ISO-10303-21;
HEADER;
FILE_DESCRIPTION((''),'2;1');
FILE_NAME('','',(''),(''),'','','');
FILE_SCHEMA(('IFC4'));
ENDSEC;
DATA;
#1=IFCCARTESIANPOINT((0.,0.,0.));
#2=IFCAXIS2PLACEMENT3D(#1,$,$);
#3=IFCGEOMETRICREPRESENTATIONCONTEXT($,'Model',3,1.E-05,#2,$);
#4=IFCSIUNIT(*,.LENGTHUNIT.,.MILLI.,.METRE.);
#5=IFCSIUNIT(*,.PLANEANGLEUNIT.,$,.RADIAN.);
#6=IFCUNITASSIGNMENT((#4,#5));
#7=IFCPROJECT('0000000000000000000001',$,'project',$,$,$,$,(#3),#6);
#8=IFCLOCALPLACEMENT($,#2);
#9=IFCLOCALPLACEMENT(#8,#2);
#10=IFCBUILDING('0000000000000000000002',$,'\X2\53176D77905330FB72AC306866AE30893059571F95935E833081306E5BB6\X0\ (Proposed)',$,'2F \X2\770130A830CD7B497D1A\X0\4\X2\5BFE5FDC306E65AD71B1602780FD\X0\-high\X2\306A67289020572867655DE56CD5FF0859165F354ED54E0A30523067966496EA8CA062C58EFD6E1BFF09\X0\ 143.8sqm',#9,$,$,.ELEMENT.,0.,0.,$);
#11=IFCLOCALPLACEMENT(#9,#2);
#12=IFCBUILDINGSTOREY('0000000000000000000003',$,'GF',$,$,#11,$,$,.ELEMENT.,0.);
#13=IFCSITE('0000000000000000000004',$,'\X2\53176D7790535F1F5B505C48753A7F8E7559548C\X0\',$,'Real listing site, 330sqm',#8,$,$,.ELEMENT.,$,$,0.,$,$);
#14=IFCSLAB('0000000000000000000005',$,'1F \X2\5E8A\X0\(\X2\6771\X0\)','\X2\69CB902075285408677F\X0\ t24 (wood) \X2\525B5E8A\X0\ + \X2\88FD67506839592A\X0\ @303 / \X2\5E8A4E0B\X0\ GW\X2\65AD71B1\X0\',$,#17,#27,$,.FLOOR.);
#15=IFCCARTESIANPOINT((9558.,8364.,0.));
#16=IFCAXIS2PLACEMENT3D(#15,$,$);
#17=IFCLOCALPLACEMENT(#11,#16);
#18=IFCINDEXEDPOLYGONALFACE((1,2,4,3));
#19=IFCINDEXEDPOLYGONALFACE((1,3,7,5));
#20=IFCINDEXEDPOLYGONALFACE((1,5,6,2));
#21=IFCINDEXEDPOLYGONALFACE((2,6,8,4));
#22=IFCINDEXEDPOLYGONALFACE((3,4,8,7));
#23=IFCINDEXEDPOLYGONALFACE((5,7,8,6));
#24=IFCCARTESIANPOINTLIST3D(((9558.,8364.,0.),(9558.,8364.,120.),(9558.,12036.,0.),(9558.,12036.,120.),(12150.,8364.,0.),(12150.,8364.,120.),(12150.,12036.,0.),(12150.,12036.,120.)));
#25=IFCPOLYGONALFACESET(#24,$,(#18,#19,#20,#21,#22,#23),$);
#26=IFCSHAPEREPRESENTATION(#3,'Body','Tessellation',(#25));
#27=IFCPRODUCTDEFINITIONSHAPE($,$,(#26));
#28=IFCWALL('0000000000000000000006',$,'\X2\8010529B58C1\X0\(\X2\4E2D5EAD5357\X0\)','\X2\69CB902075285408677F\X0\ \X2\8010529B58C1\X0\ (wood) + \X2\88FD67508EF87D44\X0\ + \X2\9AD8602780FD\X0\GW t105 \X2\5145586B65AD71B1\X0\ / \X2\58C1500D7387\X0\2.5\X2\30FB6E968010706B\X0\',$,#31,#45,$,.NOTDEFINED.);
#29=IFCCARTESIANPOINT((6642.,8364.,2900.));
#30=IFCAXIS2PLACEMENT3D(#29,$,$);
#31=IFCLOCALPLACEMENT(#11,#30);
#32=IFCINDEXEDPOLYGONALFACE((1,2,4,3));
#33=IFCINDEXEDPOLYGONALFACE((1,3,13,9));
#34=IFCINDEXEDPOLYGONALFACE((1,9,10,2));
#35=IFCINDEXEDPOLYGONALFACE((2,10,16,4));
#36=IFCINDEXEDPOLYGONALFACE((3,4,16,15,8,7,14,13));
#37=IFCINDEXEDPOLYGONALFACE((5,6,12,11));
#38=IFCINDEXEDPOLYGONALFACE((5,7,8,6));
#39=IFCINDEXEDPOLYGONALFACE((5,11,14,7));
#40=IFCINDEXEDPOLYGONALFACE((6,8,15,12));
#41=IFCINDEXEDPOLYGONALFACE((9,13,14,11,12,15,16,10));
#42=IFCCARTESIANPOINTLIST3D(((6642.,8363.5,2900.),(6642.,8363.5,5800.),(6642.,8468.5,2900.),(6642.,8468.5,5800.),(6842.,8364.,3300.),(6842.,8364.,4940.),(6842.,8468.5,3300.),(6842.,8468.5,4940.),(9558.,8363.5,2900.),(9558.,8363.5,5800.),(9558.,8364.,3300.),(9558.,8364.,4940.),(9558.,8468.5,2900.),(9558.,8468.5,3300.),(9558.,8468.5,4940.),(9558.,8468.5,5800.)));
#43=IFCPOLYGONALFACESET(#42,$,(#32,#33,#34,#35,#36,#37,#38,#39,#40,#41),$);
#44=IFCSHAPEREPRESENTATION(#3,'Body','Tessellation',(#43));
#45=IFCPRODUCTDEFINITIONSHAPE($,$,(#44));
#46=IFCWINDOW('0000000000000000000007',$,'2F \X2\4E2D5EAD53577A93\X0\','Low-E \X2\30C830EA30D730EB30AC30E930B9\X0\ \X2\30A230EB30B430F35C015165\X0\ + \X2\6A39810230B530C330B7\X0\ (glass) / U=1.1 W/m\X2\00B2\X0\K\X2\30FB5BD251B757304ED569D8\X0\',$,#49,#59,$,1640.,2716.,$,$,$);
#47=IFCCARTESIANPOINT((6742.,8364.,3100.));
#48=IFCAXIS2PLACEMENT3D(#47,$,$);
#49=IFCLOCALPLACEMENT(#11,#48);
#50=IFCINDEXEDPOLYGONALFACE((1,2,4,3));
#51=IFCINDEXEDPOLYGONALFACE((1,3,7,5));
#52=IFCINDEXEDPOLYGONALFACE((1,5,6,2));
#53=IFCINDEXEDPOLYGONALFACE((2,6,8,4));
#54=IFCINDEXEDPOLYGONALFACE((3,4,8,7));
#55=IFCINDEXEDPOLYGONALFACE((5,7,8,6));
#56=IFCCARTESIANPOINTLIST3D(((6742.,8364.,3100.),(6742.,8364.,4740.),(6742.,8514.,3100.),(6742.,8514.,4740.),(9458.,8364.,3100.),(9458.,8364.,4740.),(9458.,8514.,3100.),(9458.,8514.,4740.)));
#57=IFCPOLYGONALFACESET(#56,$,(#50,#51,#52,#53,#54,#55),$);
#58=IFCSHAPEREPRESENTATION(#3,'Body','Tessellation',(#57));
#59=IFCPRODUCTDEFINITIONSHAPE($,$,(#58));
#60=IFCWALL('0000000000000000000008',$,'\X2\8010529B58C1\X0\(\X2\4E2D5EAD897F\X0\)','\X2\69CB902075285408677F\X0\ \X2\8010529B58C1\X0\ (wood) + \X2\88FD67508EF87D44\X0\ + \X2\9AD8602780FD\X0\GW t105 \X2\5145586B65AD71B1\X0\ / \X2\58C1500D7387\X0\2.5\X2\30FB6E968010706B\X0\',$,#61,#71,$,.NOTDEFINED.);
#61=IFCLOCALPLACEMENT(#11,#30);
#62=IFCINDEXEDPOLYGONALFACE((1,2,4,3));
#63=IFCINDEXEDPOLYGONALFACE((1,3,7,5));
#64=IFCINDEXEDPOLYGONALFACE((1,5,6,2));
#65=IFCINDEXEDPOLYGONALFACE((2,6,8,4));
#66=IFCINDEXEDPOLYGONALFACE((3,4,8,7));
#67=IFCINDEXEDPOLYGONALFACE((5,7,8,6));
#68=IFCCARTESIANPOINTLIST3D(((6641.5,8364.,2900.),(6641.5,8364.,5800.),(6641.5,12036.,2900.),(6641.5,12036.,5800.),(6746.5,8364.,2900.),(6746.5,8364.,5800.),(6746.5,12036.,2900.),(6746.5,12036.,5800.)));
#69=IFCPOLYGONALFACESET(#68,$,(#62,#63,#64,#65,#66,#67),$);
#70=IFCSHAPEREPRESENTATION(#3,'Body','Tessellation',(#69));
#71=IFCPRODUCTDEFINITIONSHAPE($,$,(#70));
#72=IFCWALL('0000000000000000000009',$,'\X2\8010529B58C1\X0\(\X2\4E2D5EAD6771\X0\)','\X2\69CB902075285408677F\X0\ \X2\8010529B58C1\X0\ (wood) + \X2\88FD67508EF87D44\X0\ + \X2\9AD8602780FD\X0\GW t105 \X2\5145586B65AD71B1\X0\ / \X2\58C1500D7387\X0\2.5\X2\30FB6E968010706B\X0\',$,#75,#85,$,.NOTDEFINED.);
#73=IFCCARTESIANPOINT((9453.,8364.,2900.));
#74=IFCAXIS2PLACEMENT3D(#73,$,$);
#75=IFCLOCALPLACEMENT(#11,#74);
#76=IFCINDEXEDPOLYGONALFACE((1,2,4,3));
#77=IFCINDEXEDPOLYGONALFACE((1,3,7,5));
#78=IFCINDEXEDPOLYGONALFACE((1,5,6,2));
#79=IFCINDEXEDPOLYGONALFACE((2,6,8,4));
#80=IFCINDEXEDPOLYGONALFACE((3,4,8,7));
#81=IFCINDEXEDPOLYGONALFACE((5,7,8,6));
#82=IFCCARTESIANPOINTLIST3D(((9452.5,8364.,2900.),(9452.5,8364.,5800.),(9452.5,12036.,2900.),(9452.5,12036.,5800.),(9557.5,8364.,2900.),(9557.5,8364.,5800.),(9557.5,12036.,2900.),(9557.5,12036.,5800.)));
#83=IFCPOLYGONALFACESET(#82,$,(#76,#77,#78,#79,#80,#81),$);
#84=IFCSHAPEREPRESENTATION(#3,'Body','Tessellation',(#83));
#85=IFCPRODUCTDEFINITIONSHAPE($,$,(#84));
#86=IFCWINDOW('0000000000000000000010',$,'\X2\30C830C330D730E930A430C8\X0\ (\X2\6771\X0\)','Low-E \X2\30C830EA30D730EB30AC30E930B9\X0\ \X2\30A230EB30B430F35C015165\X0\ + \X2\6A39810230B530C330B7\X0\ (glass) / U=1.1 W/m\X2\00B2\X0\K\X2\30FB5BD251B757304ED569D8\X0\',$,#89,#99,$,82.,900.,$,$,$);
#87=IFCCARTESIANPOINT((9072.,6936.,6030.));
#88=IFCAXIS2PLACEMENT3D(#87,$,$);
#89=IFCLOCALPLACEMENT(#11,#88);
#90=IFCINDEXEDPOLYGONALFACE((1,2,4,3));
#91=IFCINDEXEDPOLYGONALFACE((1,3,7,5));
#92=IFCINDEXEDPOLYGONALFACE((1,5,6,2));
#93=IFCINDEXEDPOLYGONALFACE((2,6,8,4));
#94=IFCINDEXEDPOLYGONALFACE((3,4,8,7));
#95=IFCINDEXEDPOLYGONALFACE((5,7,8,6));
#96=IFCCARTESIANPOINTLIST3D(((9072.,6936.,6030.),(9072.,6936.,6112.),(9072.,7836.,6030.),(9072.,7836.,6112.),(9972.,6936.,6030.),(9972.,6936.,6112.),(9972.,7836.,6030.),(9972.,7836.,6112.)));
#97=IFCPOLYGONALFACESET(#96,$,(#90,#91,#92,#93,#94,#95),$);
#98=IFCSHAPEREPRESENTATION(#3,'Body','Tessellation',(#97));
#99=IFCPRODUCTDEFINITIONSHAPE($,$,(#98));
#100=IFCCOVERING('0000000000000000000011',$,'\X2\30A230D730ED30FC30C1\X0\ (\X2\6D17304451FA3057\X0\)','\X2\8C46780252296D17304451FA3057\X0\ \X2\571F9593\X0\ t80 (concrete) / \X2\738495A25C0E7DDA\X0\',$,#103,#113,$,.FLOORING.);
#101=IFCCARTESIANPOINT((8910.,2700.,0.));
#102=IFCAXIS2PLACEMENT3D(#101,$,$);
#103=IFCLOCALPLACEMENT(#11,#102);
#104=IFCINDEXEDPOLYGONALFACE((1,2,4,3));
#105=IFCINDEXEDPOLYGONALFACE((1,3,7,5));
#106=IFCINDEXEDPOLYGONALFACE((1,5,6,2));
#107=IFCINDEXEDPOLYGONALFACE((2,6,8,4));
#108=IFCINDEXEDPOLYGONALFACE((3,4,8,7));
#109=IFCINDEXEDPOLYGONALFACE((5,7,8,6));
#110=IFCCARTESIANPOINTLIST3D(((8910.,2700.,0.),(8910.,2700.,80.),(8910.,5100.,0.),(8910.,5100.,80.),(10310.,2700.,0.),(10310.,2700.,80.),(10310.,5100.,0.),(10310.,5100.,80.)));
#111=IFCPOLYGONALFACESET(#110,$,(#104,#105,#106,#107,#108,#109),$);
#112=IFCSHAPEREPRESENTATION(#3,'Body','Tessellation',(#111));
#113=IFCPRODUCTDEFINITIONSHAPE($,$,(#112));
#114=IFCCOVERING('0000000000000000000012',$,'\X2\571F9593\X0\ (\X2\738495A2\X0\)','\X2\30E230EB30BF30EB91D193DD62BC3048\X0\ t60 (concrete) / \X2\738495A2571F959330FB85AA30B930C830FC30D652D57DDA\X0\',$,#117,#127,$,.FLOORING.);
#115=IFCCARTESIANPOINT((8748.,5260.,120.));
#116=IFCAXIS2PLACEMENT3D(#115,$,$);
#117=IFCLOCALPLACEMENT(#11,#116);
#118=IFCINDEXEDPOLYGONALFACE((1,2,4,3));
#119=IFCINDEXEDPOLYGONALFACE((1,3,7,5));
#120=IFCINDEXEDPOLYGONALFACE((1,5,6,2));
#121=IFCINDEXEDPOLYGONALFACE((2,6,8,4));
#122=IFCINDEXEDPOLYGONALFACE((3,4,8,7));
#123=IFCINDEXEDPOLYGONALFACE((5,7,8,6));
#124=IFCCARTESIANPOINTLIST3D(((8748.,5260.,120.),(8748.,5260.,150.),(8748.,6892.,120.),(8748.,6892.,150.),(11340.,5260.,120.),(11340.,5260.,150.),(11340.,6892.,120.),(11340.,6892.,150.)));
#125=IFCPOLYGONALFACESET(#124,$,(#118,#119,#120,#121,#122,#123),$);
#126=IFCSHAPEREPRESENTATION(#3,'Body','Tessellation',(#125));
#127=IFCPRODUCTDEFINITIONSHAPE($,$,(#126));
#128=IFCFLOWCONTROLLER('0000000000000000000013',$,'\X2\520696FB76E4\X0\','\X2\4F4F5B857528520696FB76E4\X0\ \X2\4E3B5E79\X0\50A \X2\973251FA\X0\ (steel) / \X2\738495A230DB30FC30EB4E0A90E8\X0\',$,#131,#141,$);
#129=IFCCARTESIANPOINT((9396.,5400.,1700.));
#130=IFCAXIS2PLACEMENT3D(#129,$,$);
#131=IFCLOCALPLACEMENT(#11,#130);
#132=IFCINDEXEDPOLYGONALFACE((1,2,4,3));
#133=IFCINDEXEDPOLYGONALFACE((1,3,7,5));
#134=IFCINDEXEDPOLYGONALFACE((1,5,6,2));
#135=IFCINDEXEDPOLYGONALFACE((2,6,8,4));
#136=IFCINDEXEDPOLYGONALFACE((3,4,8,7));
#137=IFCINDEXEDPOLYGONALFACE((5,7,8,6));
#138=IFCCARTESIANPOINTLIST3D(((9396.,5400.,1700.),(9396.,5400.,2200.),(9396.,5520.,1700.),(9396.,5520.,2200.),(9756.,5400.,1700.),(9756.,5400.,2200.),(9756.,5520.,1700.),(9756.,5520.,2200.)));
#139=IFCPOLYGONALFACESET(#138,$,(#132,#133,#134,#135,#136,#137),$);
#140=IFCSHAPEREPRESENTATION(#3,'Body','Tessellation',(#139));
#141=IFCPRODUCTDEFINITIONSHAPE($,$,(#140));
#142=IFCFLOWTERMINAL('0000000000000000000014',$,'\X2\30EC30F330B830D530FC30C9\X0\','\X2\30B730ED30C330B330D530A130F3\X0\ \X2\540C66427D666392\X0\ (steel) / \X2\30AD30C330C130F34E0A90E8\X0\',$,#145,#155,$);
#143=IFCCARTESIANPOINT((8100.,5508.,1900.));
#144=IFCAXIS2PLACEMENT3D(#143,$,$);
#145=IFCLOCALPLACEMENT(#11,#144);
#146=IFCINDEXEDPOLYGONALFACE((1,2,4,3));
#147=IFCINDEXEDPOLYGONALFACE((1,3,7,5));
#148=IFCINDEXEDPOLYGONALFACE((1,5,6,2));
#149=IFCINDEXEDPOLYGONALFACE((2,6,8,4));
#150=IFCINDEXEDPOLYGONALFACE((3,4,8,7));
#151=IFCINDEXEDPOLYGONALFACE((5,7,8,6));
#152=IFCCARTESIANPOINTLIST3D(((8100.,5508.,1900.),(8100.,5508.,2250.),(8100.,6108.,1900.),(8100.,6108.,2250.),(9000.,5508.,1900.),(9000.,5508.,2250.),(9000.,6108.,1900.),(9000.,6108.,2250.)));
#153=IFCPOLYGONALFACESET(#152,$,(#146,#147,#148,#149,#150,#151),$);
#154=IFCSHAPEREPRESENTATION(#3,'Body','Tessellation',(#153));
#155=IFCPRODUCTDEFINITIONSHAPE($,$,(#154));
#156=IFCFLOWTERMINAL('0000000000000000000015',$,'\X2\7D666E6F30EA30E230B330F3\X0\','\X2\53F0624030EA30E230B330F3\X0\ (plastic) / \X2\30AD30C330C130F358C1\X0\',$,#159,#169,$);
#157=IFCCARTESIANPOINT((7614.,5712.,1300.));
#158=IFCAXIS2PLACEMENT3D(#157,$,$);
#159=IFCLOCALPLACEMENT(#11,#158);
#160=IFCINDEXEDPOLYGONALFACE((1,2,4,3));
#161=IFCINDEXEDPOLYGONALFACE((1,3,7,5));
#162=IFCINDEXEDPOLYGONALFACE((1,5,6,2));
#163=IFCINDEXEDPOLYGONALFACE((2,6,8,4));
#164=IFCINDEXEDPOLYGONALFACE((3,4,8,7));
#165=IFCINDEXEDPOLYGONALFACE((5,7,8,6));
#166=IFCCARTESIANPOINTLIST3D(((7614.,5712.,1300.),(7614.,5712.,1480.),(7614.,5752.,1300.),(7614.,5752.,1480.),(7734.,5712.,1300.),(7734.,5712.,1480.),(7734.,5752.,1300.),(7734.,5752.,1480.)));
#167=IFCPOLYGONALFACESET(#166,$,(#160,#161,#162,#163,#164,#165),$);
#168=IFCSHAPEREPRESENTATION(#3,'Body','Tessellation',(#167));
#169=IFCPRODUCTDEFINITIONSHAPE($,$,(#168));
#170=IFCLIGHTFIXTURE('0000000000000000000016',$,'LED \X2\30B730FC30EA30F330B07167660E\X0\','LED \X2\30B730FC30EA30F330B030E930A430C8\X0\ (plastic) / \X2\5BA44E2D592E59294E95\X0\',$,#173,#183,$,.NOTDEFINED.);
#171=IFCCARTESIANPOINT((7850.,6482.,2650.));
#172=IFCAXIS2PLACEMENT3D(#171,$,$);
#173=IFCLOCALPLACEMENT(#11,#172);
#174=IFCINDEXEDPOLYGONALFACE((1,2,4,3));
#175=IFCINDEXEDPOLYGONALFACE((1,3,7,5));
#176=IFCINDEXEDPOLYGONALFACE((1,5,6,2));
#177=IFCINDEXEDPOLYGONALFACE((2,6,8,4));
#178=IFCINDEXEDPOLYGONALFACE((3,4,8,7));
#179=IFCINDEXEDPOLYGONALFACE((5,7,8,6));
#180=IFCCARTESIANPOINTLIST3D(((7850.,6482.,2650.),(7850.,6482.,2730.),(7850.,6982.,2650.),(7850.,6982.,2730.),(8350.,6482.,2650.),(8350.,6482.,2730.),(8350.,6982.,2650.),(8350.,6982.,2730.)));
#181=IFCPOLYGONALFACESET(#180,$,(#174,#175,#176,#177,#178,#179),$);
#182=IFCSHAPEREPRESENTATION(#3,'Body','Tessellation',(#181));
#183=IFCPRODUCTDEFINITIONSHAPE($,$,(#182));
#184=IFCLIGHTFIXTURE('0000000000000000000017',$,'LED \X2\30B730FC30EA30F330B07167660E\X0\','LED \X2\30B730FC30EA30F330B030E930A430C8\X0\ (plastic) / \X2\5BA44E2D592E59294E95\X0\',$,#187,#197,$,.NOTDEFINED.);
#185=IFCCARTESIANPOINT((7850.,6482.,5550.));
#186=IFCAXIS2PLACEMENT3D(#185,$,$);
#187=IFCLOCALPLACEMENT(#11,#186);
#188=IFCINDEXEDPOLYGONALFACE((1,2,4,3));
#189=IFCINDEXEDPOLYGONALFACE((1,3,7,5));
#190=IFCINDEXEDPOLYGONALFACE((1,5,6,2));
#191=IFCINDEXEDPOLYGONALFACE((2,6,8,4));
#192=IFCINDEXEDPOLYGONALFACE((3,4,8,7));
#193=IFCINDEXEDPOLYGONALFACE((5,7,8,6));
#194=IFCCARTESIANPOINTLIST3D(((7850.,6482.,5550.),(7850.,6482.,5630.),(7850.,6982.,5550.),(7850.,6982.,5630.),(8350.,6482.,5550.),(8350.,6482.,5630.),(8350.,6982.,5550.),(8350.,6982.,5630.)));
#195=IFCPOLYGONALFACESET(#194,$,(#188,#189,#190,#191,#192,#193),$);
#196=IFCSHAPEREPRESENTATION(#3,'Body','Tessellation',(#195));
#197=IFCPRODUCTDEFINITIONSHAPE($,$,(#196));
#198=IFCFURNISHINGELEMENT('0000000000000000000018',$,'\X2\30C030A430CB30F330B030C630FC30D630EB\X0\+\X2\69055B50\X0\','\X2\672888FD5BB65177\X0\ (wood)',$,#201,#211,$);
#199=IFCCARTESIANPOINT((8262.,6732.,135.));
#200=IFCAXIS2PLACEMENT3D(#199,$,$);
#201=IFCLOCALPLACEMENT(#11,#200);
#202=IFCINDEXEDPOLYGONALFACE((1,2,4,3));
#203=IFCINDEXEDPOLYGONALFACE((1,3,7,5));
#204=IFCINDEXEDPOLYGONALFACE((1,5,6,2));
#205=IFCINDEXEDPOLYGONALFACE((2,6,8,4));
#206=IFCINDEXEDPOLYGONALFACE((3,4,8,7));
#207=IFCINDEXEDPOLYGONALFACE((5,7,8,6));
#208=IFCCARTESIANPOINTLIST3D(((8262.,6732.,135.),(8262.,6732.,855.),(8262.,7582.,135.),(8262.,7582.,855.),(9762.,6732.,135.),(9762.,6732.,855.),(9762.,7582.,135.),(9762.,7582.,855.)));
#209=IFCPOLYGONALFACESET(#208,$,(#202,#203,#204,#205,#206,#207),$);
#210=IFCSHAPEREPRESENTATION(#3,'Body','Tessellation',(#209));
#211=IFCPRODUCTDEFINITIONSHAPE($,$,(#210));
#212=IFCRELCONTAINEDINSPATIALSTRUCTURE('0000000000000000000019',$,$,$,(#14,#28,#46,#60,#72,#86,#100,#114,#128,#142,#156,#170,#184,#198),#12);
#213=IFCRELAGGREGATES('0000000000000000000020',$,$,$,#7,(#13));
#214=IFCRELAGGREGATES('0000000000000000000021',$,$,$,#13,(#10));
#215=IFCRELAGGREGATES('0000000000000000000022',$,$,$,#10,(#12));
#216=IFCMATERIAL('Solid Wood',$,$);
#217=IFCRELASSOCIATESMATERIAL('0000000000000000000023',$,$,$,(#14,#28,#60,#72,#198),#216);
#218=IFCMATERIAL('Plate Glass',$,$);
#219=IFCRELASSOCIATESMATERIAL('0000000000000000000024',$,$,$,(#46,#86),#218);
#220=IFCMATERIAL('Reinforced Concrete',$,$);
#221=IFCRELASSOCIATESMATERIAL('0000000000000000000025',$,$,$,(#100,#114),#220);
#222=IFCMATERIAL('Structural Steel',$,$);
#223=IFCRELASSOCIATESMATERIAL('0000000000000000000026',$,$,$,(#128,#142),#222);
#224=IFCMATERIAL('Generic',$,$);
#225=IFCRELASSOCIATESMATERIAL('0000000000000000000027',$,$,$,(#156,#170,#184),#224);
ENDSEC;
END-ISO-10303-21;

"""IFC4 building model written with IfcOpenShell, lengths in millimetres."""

from ifc_helpers import new_model, si_unit, frame, frame_2d, origin, place, context, project, spatial, rectangle, extrude, material, element, fill, save


model = new_model("IFC4")

# Units and contexts
model_context = context("Model", 3, precision=1e-05, world=origin())
ifc_project = project(units=[si_unit("LENGTHUNIT", "METRE", prefix="MILLI"), si_unit("PLANEANGLEUNIT", "RADIAN")], contexts=[model_context])

# Site, building, storey
site_placement = place(None, origin())
site = spatial("IfcSite", under=ifc_project, at=site_placement, Name="北海道弟子屈町美留和", ObjectType="Real listing site, 330sqm", CompositionType="ELEMENT", RefElevation=0.0)
building_placement = place(site_placement, origin())
building = spatial("IfcBuilding", under=site, at=building_placement, Name="北海道・犬と暮らす土間広めの家 (Proposed)", ObjectType="2F 省エネ等級4対応の断熱性能-highな木造在来工法（外張仕上げで除雪負担軽減） 143.8sqm", CompositionType="ELEMENT", ElevationOfRefHeight=0.0, ElevationOfTerrain=0.0)
storey_placement = place(building_placement, origin())
storey = spatial("IfcBuildingStorey", under=building, at=storey_placement, Name="GF", CompositionType="ELEMENT", Elevation=0.0)

# Shared definitions
ifc_material_1 = material(Name="Solid Wood")

# Slab
slab_placement = place(storey_placement, frame((9558.0, 8364.0, 0.0)))
element("IfcSlab", 1, at=slab_placement, inside=storey, material=ifc_material_1, Name="1F 床(東)", Description="構造用合板 t24 (wood) 剛床 + 製材根太 @303 / 床下 GW断熱", PredefinedType="FLOOR", context=model_context, shape_type="SweptSolid", body=[
    extrude(rectangle(XDim=2592.0, YDim=3672.0, at=frame_2d((1296.0, 1836.0))), frame((9558.0, 8364.0, 0.0)), (0.0, 0.0, 1.0), 120.0),
])

# Wall, opening, window
wall_1_placement = place(storey_placement, frame((6642.0, 8364.0, 2900.0)))
wall_1 = element("IfcWall", 2, at=wall_1_placement, inside=storey, material=ifc_material_1, Name="耐力壁(中庭南)", Description="構造用合板 耐力壁 (wood) + 製材軸組 + 高性能GW t105 充填断熱 / 壁倍率2.5・準耐火", PredefinedType="NOTDEFINED", context=model_context, shape_type="SweptSolid", body=[
    extrude(rectangle(XDim=2916.0, YDim=105.0, at=frame_2d((1458.0, 52.0))), frame((6642.0, 8364.0, 2900.0)), (0.0, 0.0, 1.0), 2900.0),
])
opening_placement = place(storey_placement, frame((6742.0, 8364.0, 3100.0)))
opening = element("IfcOpeningElement", 3, at=opening_placement, cuts=wall_1, PredefinedType="NOTDEFINED", context=model_context, shape_type="SweptSolid", body=[
    extrude(rectangle(XDim=2716.0, YDim=150.0, at=frame_2d((1358.0, 75.0))), frame((6742.0, 8364.0, 3100.0)), (0.0, 0.0, 1.0), 1640.0),
])
ifc_material_2 = material(Name="Plate Glass")
window_1_placement = place(storey_placement, frame((6742.0, 8364.0, 3100.0)))
window_1 = element("IfcWindow", 4, at=window_1_placement, inside=storey, material=ifc_material_2, Name="2F 中庭南窓", Description="Low-E トリプルガラス アルゴン封入 + 樹脂サッシ (glass) / U=1.1 W/m²K・寒冷地仕様", OverallHeight=1640.0, OverallWidth=2716.0, context=model_context, shape_type="SweptSolid", body=[
    extrude(rectangle(XDim=2716.0, YDim=150.0, at=frame_2d((1358.0, 75.0))), frame((6742.0, 8364.0, 3100.0)), (0.0, 0.0, 1.0), 1640.0),
])
fill(opening, window_1)

# Walls
wall_2_placement = place(storey_placement, frame((6642.0, 8364.0, 2900.0)))
element("IfcWall", 5, at=wall_2_placement, inside=storey, material=ifc_material_1, Name="耐力壁(中庭西)", Description="構造用合板 耐力壁 (wood) + 製材軸組 + 高性能GW t105 充填断熱 / 壁倍率2.5・準耐火", PredefinedType="NOTDEFINED", context=model_context, shape_type="SweptSolid", body=[
    extrude(rectangle(XDim=105.0, YDim=3672.0, at=frame_2d((52.0, 1836.0))), frame((6642.0, 8364.0, 2900.0)), (0.0, 0.0, 1.0), 2900.0),
])
wall_3_placement = place(storey_placement, frame((9453.0, 8364.0, 2900.0)))
element("IfcWall", 6, at=wall_3_placement, inside=storey, material=ifc_material_1, Name="耐力壁(中庭東)", Description="構造用合板 耐力壁 (wood) + 製材軸組 + 高性能GW t105 充填断熱 / 壁倍率2.5・準耐火", PredefinedType="NOTDEFINED", context=model_context, shape_type="SweptSolid", body=[
    extrude(rectangle(XDim=105.0, YDim=3672.0, at=frame_2d((52.0, 1836.0))), frame((9453.0, 8364.0, 2900.0)), (0.0, 0.0, 1.0), 2900.0),
])

# Window
window_2_placement = place(storey_placement, frame((9072.0, 6936.0, 6030.0)))
element("IfcWindow", 7, at=window_2_placement, inside=storey, material=ifc_material_2, Name="トップライト (東)", Description="Low-E トリプルガラス アルゴン封入 + 樹脂サッシ (glass) / U=1.1 W/m²K・寒冷地仕様", OverallHeight=82.0, OverallWidth=900.0, context=model_context, shape_type="SweptSolid", body=[
    extrude(rectangle(XDim=900.0, YDim=900.0, at=frame_2d((450.0, 450.0))), frame((9072.0, 6936.0, 6030.0)), (0.0, 0.0, 1.0), 82.0),
])

# Coverings
ifc_material_3 = material(Name="Reinforced Concrete")
covering_1_placement = place(storey_placement, frame((8910.0, 2700.0, 0.0)))
element("IfcCovering", 8, at=covering_1_placement, inside=storey, material=ifc_material_3, Name="アプローチ (洗い出し)", Description="豆砂利洗い出し 土間 t80 (concrete) / 玄関導線", PredefinedType="FLOORING", context=model_context, shape_type="SweptSolid", body=[
    extrude(rectangle(XDim=1400.0, YDim=2400.0, at=frame_2d((700.0, 1200.0))), frame((8910.0, 2700.0, 0.0)), (0.0, 0.0, 1.0), 80.0),
])
covering_2_placement = place(storey_placement, frame((8748.0, 5260.0, 120.0)))
element("IfcCovering", 9, at=covering_2_placement, inside=storey, material=ifc_material_3, Name="土間 (玄関)", Description="モルタル金鏝押え t60 (concrete) / 玄関土間・薪ストーブ動線", PredefinedType="FLOORING", context=model_context, shape_type="SweptSolid", body=[
    extrude(rectangle(XDim=2592.0, YDim=1632.0, at=frame_2d((1296.0, 816.0))), frame((8748.0, 5260.0, 120.0)), (0.0, 0.0, 1.0), 30.0),
])

# Flow controller
ifc_material_4 = material(Name="Structural Steel")
flow_controller_placement = place(storey_placement, frame((9396.0, 5400.0, 1700.0)))
element("IfcFlowController", 10, at=flow_controller_placement, inside=storey, material=ifc_material_4, Name="分電盤", Description="住宅用分電盤 主幹50A 露出 (steel) / 玄関ホール上部", context=model_context, shape_type="SweptSolid", body=[
    extrude(rectangle(XDim=360.0, YDim=120.0, at=frame_2d((180.0, 60.0))), frame((9396.0, 5400.0, 1700.0)), (0.0, 0.0, 1.0), 500.0),
])

# Flow terminals
flow_terminal_1_placement = place(storey_placement, frame((8100.0, 5508.0, 1900.0)))
element("IfcFlowTerminal", 11, at=flow_terminal_1_placement, inside=storey, material=ifc_material_4, Name="レンジフード", Description="シロッコファン 同時給排 (steel) / キッチン上部", context=model_context, shape_type="SweptSolid", body=[
    extrude(rectangle(XDim=900.0, YDim=600.0, at=frame_2d((450.0, 300.0))), frame((8100.0, 5508.0, 1900.0)), (0.0, 0.0, 1.0), 350.0),
])
ifc_material_5 = material(Name="Generic")
flow_terminal_2_placement = place(storey_placement, frame((7614.0, 5712.0, 1300.0)))
element("IfcFlowTerminal", 12, at=flow_terminal_2_placement, inside=storey, material=ifc_material_5, Name="給湯リモコン", Description="台所リモコン (plastic) / キッチン壁", context=model_context, shape_type="SweptSolid", body=[
    extrude(rectangle(XDim=120.0, YDim=40.0, at=frame_2d((60.0, 20.0))), frame((7614.0, 5712.0, 1300.0)), (0.0, 0.0, 1.0), 180.0),
])

# Light fixtures
light_fixture_1_placement = place(storey_placement, frame((7850.0, 6482.0, 2650.0)))
element("IfcLightFixture", 13, at=light_fixture_1_placement, inside=storey, material=ifc_material_5, Name="LED シーリング照明", Description="LED シーリングライト (plastic) / 室中央天井", PredefinedType="NOTDEFINED", context=model_context, shape_type="SweptSolid", body=[
    extrude(rectangle(XDim=500.0, YDim=500.0, at=frame_2d((250.0, 250.0))), frame((7850.0, 6482.0, 2650.0)), (0.0, 0.0, 1.0), 80.0),
])
light_fixture_2_placement = place(storey_placement, frame((7850.0, 6482.0, 5550.0)))
element("IfcLightFixture", 14, at=light_fixture_2_placement, inside=storey, material=ifc_material_5, Name="LED シーリング照明", Description="LED シーリングライト (plastic) / 室中央天井", PredefinedType="NOTDEFINED", context=model_context, shape_type="SweptSolid", body=[
    extrude(rectangle(XDim=500.0, YDim=500.0, at=frame_2d((250.0, 250.0))), frame((7850.0, 6482.0, 5550.0)), (0.0, 0.0, 1.0), 80.0),
])

# Furnishing element
furnishing_1_placement = place(storey_placement, frame((8262.0, 6732.0, 135.0)))
element("IfcFurnishingElement", 15, at=furnishing_1_placement, inside=storey, material=ifc_material_1, Name="ダイニングテーブル+椅子", Description="木製家具 (wood)", context=model_context, shape_type="SweptSolid", body=[
    extrude(rectangle(XDim=1500.0, YDim=850.0, at=frame_2d((750.0, 425.0))), frame((8262.0, 6732.0, 135.0)), (0.0, 0.0, 1.0), 720.0),
])

save(model, "model.ifc")
